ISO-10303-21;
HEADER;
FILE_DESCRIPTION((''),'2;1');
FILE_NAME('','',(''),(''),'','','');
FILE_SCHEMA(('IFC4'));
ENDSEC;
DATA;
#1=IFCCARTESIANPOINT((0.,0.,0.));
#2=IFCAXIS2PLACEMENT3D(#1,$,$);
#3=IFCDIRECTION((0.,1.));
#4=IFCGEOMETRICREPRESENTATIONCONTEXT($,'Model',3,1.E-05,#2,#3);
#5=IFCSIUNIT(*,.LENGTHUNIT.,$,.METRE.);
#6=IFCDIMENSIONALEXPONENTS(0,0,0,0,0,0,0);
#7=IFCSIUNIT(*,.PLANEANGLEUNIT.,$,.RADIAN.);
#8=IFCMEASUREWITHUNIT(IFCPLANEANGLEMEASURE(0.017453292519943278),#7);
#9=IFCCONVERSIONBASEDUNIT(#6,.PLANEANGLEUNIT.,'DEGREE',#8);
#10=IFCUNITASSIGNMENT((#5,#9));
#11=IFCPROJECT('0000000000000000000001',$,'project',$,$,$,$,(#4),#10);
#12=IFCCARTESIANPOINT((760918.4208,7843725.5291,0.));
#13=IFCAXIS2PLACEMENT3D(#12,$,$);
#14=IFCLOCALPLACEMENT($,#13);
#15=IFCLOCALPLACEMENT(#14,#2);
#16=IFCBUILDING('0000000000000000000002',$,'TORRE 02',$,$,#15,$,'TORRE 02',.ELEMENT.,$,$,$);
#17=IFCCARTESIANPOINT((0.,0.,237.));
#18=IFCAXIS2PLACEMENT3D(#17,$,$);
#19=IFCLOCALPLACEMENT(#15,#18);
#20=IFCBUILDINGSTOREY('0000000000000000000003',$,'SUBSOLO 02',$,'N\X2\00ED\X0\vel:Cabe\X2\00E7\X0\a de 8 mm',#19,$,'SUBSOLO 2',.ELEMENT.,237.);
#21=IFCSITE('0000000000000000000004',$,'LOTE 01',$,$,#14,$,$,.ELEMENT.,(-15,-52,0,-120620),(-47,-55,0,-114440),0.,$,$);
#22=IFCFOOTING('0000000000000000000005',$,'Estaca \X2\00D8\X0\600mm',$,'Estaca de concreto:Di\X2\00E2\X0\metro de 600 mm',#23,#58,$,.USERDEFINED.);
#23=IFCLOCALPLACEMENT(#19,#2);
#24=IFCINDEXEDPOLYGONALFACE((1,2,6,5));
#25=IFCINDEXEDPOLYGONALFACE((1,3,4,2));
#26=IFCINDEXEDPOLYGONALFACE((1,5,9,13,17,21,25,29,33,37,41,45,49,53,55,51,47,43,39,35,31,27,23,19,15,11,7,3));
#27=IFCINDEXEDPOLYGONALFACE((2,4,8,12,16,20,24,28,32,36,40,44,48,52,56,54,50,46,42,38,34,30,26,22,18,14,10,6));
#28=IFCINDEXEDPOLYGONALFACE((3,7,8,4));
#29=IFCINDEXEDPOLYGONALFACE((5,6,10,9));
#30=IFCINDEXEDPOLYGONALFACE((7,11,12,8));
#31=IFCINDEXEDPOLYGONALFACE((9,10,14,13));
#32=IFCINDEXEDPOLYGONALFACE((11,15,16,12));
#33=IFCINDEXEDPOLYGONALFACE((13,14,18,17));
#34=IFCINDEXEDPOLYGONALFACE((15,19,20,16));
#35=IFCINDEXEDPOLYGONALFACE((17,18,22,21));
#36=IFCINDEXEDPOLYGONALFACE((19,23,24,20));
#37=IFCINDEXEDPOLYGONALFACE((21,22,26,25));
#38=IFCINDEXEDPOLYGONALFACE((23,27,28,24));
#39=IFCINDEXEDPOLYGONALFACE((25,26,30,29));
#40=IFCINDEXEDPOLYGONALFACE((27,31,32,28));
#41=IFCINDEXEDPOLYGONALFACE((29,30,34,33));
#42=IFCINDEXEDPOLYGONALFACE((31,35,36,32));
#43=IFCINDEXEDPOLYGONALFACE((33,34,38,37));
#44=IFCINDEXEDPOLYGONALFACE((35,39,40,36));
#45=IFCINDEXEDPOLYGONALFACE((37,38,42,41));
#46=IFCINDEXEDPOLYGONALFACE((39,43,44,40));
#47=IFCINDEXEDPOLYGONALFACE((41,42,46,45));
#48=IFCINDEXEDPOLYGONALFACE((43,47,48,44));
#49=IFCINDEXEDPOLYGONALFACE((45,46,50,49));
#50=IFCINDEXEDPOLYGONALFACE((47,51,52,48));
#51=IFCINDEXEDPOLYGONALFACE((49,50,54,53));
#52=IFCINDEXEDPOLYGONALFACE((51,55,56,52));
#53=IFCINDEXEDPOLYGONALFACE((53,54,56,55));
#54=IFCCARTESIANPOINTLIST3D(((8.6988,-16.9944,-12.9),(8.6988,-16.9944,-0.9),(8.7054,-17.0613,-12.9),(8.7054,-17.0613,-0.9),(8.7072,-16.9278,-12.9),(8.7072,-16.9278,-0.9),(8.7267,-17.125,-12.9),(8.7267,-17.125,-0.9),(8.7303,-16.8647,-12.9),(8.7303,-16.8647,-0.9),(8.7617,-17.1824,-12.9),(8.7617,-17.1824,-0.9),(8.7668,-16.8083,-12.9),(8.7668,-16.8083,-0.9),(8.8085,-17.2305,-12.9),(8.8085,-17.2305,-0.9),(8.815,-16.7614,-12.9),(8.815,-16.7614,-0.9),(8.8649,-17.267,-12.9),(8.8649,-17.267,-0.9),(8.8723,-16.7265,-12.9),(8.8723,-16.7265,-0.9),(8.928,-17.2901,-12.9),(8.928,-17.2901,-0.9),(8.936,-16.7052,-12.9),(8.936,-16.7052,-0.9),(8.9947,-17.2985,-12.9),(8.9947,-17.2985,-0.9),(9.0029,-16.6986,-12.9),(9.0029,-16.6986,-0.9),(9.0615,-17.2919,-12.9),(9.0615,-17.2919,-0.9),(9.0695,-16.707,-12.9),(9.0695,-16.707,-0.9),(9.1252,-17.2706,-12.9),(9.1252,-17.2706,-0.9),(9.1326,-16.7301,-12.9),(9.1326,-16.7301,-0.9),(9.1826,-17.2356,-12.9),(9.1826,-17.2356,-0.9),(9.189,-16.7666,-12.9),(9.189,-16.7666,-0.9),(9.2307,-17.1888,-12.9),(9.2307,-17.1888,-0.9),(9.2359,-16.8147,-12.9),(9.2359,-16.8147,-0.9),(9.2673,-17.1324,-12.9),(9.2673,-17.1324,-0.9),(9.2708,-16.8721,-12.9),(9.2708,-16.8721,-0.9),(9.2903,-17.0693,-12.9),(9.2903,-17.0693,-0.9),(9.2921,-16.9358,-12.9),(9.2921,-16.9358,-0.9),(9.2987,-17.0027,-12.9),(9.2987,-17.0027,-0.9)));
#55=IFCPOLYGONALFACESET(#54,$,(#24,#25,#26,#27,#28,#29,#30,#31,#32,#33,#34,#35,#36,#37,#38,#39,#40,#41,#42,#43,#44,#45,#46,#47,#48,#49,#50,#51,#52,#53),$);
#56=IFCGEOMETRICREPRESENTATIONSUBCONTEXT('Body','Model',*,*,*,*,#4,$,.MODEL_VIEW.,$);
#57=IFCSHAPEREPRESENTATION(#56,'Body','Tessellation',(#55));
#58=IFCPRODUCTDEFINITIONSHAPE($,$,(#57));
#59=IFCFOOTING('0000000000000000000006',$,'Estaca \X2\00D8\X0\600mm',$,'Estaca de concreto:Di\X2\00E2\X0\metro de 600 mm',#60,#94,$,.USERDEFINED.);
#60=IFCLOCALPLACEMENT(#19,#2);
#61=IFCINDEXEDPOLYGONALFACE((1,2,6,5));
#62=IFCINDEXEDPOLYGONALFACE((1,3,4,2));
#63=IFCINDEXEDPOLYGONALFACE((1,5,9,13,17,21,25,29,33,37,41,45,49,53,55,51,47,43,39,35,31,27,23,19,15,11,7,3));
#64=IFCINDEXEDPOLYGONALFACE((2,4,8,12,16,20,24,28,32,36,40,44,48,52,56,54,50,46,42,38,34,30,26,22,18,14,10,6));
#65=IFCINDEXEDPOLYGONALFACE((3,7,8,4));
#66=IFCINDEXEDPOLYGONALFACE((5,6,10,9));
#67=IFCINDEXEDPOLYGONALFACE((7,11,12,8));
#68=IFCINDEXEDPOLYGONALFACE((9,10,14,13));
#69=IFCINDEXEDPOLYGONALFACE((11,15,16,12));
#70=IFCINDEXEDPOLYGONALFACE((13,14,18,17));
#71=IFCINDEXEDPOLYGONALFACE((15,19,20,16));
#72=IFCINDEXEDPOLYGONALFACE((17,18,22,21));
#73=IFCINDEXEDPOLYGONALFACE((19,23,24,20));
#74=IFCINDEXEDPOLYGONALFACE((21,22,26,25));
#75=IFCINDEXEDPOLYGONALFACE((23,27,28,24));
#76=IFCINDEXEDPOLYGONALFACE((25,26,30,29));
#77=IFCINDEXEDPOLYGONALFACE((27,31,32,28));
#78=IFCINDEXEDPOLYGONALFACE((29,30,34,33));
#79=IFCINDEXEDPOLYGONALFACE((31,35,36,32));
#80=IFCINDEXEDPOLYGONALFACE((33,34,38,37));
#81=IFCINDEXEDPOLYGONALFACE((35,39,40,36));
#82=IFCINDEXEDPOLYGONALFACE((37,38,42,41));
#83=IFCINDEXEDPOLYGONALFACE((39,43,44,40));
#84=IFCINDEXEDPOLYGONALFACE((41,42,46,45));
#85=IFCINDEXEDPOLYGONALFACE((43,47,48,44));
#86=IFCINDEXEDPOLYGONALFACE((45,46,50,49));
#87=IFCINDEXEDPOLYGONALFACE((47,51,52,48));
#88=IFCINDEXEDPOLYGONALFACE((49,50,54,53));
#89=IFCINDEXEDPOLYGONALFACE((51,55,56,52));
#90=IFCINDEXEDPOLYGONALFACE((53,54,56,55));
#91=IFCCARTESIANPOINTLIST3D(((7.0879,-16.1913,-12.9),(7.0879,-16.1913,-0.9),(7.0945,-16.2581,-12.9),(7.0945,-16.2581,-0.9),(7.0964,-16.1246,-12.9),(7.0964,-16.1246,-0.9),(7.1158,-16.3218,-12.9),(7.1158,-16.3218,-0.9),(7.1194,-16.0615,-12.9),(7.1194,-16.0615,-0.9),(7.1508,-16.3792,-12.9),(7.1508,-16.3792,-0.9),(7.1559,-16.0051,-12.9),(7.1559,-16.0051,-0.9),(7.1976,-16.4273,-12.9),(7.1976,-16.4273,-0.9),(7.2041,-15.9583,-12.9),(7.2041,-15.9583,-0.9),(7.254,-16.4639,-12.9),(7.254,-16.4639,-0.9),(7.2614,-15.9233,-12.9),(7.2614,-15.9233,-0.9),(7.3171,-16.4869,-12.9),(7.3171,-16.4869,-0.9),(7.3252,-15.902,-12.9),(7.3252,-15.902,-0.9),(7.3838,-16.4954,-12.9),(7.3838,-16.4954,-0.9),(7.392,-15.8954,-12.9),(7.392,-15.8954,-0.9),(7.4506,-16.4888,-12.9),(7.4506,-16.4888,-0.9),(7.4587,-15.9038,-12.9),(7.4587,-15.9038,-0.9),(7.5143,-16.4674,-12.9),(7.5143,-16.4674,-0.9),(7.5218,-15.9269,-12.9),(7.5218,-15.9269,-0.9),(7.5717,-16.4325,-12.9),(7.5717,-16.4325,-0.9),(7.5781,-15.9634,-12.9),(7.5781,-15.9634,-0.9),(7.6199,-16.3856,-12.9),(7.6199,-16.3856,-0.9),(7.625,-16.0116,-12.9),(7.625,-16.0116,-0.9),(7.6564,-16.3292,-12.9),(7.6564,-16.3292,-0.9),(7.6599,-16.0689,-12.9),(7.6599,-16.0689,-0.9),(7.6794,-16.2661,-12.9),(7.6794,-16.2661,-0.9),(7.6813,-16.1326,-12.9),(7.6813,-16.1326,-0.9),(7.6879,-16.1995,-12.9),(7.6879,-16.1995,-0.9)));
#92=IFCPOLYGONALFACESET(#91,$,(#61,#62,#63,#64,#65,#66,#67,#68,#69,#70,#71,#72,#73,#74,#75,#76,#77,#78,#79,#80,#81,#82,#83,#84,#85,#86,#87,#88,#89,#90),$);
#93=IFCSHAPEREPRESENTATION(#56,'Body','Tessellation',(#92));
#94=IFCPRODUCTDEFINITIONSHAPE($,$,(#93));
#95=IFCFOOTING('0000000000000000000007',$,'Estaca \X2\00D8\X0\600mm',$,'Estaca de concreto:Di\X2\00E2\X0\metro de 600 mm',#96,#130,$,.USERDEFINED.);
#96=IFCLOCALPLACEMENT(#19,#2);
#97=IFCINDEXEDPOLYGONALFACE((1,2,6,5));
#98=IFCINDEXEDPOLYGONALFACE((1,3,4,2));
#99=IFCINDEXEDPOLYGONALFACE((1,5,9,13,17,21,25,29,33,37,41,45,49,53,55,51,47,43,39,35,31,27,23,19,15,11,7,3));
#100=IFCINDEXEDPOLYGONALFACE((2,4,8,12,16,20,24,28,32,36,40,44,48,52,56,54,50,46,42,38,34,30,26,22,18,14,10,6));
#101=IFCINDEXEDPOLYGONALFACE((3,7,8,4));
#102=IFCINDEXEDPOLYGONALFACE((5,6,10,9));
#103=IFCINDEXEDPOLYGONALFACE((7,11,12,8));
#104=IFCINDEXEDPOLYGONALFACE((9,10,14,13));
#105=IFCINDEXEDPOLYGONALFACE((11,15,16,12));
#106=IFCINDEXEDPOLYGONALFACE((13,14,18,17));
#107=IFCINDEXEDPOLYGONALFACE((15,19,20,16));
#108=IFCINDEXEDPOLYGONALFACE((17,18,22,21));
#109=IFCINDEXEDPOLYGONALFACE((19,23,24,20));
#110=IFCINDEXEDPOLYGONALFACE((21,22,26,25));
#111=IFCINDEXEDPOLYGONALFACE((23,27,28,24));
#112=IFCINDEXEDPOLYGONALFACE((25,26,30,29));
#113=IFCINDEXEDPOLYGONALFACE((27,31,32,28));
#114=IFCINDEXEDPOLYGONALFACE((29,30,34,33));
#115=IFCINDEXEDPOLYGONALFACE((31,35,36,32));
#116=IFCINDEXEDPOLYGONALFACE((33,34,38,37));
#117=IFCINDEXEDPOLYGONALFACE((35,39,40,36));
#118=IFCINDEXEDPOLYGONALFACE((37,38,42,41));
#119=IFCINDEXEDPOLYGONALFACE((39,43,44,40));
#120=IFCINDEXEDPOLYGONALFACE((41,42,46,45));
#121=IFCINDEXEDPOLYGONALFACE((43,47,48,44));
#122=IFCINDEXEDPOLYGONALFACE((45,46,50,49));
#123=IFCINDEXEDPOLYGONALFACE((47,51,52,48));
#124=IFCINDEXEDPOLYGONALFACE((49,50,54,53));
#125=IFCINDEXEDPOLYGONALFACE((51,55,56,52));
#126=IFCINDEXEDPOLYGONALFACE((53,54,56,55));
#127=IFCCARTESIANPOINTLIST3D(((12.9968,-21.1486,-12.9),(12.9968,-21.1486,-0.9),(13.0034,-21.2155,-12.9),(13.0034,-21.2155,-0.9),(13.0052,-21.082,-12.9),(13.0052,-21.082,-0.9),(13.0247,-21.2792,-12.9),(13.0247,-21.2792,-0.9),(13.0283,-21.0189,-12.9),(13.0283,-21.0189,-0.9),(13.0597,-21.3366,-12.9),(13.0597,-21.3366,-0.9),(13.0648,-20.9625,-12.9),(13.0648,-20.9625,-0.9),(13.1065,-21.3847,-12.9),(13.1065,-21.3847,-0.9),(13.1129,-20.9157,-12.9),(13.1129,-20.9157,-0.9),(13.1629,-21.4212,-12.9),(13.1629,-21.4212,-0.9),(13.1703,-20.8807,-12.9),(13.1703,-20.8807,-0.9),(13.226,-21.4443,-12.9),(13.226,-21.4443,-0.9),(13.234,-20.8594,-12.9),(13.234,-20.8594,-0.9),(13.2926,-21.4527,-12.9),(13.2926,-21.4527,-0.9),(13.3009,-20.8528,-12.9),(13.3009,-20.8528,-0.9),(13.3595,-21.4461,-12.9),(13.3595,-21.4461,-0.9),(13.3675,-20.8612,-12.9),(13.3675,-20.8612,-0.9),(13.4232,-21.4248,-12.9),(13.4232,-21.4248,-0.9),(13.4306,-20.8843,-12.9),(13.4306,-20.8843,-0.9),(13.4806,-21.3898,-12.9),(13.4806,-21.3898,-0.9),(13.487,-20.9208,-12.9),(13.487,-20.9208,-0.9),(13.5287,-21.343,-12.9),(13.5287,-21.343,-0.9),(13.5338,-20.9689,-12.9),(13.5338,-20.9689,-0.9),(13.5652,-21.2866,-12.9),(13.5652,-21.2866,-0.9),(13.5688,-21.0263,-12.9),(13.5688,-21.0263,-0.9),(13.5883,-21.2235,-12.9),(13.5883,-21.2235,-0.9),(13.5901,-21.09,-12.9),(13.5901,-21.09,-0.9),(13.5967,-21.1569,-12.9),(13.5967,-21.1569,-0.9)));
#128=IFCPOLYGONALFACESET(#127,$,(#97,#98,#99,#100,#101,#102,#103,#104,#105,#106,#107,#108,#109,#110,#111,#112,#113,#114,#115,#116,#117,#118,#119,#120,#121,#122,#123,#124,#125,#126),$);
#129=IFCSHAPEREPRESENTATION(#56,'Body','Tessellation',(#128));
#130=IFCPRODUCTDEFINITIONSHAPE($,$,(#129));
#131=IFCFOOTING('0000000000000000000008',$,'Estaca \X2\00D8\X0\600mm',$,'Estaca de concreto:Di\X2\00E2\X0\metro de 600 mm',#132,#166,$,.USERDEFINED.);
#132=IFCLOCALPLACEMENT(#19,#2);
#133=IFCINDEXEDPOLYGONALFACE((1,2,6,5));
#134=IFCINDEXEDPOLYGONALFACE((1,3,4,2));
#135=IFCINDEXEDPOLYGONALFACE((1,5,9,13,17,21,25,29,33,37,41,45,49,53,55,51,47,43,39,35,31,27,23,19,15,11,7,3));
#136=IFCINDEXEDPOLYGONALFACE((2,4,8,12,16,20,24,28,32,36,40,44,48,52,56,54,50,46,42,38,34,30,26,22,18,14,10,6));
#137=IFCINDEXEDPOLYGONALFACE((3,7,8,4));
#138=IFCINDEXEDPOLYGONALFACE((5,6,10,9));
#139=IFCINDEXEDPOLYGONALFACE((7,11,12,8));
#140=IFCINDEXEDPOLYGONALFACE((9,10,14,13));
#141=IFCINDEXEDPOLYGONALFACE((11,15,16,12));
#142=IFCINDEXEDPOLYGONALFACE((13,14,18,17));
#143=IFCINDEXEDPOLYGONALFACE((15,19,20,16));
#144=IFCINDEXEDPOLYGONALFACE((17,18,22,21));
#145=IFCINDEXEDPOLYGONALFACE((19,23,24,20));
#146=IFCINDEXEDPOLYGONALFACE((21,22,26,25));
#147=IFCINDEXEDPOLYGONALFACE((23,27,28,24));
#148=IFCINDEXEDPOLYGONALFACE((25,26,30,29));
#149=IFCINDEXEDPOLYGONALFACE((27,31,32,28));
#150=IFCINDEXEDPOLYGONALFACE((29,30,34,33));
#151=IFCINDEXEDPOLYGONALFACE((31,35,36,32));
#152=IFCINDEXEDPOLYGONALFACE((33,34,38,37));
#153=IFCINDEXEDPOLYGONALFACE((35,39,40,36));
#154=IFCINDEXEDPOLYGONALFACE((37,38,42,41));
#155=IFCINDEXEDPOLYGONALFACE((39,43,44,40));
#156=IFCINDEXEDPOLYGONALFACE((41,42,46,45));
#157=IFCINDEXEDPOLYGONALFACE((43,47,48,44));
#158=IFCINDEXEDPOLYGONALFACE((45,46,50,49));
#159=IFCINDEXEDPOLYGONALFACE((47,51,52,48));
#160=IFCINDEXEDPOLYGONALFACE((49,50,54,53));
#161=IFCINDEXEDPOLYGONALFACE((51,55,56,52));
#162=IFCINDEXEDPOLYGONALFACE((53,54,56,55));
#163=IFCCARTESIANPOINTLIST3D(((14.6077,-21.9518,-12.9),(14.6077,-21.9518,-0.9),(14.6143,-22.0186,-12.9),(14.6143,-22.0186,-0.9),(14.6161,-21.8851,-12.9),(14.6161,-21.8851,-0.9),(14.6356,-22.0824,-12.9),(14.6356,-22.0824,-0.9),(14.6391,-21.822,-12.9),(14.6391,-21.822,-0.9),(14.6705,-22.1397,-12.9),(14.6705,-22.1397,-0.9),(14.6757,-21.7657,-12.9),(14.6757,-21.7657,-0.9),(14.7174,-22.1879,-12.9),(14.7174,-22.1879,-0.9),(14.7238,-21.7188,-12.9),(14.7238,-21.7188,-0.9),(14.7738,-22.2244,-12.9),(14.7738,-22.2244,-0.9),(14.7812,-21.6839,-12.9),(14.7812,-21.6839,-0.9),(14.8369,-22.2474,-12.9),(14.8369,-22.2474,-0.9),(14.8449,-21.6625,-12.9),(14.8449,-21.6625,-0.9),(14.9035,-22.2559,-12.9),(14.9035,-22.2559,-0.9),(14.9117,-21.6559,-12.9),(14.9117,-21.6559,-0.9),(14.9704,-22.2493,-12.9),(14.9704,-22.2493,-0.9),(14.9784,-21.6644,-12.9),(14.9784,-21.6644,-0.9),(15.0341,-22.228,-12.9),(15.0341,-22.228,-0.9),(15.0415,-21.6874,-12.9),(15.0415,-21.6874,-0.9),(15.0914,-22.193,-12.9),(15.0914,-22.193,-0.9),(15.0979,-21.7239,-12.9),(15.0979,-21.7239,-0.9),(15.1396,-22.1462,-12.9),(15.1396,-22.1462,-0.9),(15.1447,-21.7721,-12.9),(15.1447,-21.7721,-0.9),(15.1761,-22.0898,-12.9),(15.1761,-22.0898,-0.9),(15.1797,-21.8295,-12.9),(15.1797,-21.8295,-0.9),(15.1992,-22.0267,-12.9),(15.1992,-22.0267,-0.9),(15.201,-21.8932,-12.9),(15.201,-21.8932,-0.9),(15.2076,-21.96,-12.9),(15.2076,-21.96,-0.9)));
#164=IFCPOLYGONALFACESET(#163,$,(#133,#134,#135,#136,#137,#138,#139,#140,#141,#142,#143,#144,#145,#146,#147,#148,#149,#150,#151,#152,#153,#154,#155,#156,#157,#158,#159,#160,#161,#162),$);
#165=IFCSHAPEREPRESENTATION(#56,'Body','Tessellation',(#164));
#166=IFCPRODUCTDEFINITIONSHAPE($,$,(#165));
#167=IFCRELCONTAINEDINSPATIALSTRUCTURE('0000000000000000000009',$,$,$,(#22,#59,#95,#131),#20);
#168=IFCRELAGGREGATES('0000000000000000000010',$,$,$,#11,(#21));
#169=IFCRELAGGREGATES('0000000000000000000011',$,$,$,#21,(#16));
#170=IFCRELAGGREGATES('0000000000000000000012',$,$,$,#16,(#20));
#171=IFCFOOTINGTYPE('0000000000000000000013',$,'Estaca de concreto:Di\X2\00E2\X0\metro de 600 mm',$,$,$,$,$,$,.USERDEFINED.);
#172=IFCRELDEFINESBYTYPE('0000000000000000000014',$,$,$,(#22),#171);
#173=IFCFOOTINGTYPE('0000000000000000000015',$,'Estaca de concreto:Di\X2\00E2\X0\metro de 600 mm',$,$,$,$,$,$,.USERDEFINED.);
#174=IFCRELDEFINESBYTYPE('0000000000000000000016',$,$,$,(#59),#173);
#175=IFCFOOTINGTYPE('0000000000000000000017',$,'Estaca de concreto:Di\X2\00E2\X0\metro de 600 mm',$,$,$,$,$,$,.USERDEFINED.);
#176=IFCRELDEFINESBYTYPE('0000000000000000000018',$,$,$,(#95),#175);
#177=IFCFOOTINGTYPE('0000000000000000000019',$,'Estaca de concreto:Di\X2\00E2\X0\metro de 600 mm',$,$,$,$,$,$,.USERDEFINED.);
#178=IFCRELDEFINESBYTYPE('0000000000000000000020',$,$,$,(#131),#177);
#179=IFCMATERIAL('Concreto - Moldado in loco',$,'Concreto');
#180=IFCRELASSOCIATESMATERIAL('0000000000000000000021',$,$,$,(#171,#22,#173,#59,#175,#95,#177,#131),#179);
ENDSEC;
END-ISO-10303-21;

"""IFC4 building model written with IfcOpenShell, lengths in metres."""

from ifc_helpers import new_model, entity, si_unit, converted_unit, direction, frame, origin, place, context, subcontext, project, spatial, arc, indexed_curve, outline, extrude, source, transform, mapped, material, type_object, type_shapes, element, save


model = new_model("IFC4")

# Units and contexts
model_context = context("Model", 3, precision=1e-05, world=origin(), true_north=direction((0.0, 1.0)))
body_context = subcontext(model_context, "Body", "Model", "MODEL_VIEW")
ifc_project = project(units=[si_unit("LENGTHUNIT", "METRE"), converted_unit("PLANEANGLEUNIT", "DEGREE", entity("IfcPlaneAngleMeasure", 0.017453292519943278), si_unit("PLANEANGLEUNIT", "RADIAN"), dimensions=[0, 0, 0, 0, 0, 0, 0])], contexts=[model_context])

# Site, building, storey
site_placement = place(None, frame((760918.4208, 7843725.5291, 0.0)))
site = spatial("IfcSite", under=ifc_project, at=site_placement, Name="LOTE 01", CompositionType="ELEMENT", RefLatitude=(-15, -52, 0, -120620), RefLongitude=(-47, -55, 0, -114440), RefElevation=0.0)
building_placement = place(site_placement, origin())
building = spatial("IfcBuilding", under=site, at=building_placement, Name="TORRE 02", LongName="TORRE 02", CompositionType="ELEMENT")
storey_placement = place(building_placement, frame((0.0, 0.0, 237.0)))
storey = spatial("IfcBuildingStorey", under=building, at=storey_placement, Name="SUBSOLO 02", ObjectType="Nível:Cabeça de 8 mm", LongName="SUBSOLO 2", CompositionType="ELEMENT", Elevation=237.0)

# Footings
ifc_material = material(Name="Concreto - Moldado in loco", Category="Concreto")
footing_type_1 = type_object("IfcFootingType", Name="Estaca de concreto:Diâmetro de 600 mm", PredefinedType="USERDEFINED", material=ifc_material)
shared_shape_1 = source(origin(), body_context, "Body", "SweptSolid", [
    extrude(outline(indexed_curve([(-0.3, 0.0), (0.0, -0.3), (0.3, 0.0), (0.0, 0.3)], segments=[arc(1, 2, 3), arc(3, 4, 1)], self_intersect=False)), frame((8.9988, -16.9985, -12.0), z_axis=(0.0, 0.0, 1.0), x_axis=(0.894934, -0.446198, 0.0)), (0.0, 0.0, 1.0), 12.0),
])
type_shapes(footing_type_1, [shared_shape_1])
placement = place(building_placement, frame((0.0, 0.0, 237.0)))
footing_1_placement = place(placement, frame((0.0, 0.0, -0.9)))
element("IfcFooting", 1, at=footing_1_placement, inside=storey, type_object=footing_type_1, material=ifc_material, Name="Estaca Ø600mm", ObjectType="Estaca de concreto:Diâmetro de 600 mm", PredefinedType="USERDEFINED", context=body_context, shape_type="MappedRepresentation", body=[
    mapped(shared_shape_1, transform((0.0, 0.0, 0.0), scale=1.0)),
])
footing_type_2 = type_object("IfcFootingType", Name="Estaca de concreto:Diâmetro de 600 mm", PredefinedType="USERDEFINED", material=ifc_material)
shared_shape_2 = source(origin(), body_context, "Body", "SweptSolid", [
    extrude(outline(indexed_curve([(-0.3, 0.0), (0.0, -0.3), (0.3, 0.0), (0.0, 0.3)], segments=[arc(1, 2, 3), arc(3, 4, 1)], self_intersect=False)), frame((7.3879, -16.1954, -12.0), z_axis=(0.0, 0.0, 1.0), x_axis=(0.894934, -0.446198, 0.0)), (0.0, 0.0, 1.0), 12.0),
])
type_shapes(footing_type_2, [shared_shape_2])
footing_2_placement = place(placement, frame((0.0, 0.0, -0.9)))
element("IfcFooting", 2, at=footing_2_placement, inside=storey, type_object=footing_type_2, material=ifc_material, Name="Estaca Ø600mm", ObjectType="Estaca de concreto:Diâmetro de 600 mm", PredefinedType="USERDEFINED", context=body_context, shape_type="MappedRepresentation", body=[
    mapped(shared_shape_2, transform((0.0, 0.0, 0.0), scale=1.0)),
])
footing_type_3 = type_object("IfcFootingType", Name="Estaca de concreto:Diâmetro de 600 mm", PredefinedType="USERDEFINED", material=ifc_material)
shared_shape_3 = source(origin(), body_context, "Body", "SweptSolid", [
    extrude(outline(indexed_curve([(-0.3, 0.0), (0.0, -0.3), (0.3, 0.0), (0.0, 0.3)], segments=[arc(1, 2, 3), arc(3, 4, 1)], self_intersect=False)), frame((13.2967, -21.1527, -12.0), z_axis=(0.0, 0.0, 1.0), x_axis=(0.894934, -0.446198, 0.0)), (0.0, 0.0, 1.0), 12.0),
])
type_shapes(footing_type_3, [shared_shape_3])
footing_3_placement = place(placement, frame((0.0, 0.0, -0.9)))
element("IfcFooting", 3, at=footing_3_placement, inside=storey, type_object=footing_type_3, material=ifc_material, Name="Estaca Ø600mm", ObjectType="Estaca de concreto:Diâmetro de 600 mm", PredefinedType="USERDEFINED", context=body_context, shape_type="MappedRepresentation", body=[
    mapped(shared_shape_3, transform((0.0, 0.0, 0.0), scale=1.0)),
])
footing_type_4 = type_object("IfcFootingType", Name="Estaca de concreto:Diâmetro de 600 mm", PredefinedType="USERDEFINED", material=ifc_material)
shared_shape_4 = source(origin(), body_context, "Body", "SweptSolid", [
    extrude(outline(indexed_curve([(-0.3, 0.0), (0.0, -0.3), (0.3, 0.0), (0.0, 0.3)], segments=[arc(1, 2, 3), arc(3, 4, 1)], self_intersect=False)), frame((14.9076, -21.9559, -12.0), z_axis=(0.0, 0.0, 1.0), x_axis=(0.894934, -0.446198, 0.0)), (0.0, 0.0, 1.0), 12.0),
])
type_shapes(footing_type_4, [shared_shape_4])
footing_4_placement = place(placement, frame((0.0, 0.0, -0.9)))
element("IfcFooting", 4, at=footing_4_placement, inside=storey, type_object=footing_type_4, material=ifc_material, Name="Estaca Ø600mm", ObjectType="Estaca de concreto:Diâmetro de 600 mm", PredefinedType="USERDEFINED", context=body_context, shape_type="MappedRepresentation", body=[
    mapped(shared_shape_4, transform((0.0, 0.0, 0.0), scale=1.0)),
])

save(model, "model.ifc")
